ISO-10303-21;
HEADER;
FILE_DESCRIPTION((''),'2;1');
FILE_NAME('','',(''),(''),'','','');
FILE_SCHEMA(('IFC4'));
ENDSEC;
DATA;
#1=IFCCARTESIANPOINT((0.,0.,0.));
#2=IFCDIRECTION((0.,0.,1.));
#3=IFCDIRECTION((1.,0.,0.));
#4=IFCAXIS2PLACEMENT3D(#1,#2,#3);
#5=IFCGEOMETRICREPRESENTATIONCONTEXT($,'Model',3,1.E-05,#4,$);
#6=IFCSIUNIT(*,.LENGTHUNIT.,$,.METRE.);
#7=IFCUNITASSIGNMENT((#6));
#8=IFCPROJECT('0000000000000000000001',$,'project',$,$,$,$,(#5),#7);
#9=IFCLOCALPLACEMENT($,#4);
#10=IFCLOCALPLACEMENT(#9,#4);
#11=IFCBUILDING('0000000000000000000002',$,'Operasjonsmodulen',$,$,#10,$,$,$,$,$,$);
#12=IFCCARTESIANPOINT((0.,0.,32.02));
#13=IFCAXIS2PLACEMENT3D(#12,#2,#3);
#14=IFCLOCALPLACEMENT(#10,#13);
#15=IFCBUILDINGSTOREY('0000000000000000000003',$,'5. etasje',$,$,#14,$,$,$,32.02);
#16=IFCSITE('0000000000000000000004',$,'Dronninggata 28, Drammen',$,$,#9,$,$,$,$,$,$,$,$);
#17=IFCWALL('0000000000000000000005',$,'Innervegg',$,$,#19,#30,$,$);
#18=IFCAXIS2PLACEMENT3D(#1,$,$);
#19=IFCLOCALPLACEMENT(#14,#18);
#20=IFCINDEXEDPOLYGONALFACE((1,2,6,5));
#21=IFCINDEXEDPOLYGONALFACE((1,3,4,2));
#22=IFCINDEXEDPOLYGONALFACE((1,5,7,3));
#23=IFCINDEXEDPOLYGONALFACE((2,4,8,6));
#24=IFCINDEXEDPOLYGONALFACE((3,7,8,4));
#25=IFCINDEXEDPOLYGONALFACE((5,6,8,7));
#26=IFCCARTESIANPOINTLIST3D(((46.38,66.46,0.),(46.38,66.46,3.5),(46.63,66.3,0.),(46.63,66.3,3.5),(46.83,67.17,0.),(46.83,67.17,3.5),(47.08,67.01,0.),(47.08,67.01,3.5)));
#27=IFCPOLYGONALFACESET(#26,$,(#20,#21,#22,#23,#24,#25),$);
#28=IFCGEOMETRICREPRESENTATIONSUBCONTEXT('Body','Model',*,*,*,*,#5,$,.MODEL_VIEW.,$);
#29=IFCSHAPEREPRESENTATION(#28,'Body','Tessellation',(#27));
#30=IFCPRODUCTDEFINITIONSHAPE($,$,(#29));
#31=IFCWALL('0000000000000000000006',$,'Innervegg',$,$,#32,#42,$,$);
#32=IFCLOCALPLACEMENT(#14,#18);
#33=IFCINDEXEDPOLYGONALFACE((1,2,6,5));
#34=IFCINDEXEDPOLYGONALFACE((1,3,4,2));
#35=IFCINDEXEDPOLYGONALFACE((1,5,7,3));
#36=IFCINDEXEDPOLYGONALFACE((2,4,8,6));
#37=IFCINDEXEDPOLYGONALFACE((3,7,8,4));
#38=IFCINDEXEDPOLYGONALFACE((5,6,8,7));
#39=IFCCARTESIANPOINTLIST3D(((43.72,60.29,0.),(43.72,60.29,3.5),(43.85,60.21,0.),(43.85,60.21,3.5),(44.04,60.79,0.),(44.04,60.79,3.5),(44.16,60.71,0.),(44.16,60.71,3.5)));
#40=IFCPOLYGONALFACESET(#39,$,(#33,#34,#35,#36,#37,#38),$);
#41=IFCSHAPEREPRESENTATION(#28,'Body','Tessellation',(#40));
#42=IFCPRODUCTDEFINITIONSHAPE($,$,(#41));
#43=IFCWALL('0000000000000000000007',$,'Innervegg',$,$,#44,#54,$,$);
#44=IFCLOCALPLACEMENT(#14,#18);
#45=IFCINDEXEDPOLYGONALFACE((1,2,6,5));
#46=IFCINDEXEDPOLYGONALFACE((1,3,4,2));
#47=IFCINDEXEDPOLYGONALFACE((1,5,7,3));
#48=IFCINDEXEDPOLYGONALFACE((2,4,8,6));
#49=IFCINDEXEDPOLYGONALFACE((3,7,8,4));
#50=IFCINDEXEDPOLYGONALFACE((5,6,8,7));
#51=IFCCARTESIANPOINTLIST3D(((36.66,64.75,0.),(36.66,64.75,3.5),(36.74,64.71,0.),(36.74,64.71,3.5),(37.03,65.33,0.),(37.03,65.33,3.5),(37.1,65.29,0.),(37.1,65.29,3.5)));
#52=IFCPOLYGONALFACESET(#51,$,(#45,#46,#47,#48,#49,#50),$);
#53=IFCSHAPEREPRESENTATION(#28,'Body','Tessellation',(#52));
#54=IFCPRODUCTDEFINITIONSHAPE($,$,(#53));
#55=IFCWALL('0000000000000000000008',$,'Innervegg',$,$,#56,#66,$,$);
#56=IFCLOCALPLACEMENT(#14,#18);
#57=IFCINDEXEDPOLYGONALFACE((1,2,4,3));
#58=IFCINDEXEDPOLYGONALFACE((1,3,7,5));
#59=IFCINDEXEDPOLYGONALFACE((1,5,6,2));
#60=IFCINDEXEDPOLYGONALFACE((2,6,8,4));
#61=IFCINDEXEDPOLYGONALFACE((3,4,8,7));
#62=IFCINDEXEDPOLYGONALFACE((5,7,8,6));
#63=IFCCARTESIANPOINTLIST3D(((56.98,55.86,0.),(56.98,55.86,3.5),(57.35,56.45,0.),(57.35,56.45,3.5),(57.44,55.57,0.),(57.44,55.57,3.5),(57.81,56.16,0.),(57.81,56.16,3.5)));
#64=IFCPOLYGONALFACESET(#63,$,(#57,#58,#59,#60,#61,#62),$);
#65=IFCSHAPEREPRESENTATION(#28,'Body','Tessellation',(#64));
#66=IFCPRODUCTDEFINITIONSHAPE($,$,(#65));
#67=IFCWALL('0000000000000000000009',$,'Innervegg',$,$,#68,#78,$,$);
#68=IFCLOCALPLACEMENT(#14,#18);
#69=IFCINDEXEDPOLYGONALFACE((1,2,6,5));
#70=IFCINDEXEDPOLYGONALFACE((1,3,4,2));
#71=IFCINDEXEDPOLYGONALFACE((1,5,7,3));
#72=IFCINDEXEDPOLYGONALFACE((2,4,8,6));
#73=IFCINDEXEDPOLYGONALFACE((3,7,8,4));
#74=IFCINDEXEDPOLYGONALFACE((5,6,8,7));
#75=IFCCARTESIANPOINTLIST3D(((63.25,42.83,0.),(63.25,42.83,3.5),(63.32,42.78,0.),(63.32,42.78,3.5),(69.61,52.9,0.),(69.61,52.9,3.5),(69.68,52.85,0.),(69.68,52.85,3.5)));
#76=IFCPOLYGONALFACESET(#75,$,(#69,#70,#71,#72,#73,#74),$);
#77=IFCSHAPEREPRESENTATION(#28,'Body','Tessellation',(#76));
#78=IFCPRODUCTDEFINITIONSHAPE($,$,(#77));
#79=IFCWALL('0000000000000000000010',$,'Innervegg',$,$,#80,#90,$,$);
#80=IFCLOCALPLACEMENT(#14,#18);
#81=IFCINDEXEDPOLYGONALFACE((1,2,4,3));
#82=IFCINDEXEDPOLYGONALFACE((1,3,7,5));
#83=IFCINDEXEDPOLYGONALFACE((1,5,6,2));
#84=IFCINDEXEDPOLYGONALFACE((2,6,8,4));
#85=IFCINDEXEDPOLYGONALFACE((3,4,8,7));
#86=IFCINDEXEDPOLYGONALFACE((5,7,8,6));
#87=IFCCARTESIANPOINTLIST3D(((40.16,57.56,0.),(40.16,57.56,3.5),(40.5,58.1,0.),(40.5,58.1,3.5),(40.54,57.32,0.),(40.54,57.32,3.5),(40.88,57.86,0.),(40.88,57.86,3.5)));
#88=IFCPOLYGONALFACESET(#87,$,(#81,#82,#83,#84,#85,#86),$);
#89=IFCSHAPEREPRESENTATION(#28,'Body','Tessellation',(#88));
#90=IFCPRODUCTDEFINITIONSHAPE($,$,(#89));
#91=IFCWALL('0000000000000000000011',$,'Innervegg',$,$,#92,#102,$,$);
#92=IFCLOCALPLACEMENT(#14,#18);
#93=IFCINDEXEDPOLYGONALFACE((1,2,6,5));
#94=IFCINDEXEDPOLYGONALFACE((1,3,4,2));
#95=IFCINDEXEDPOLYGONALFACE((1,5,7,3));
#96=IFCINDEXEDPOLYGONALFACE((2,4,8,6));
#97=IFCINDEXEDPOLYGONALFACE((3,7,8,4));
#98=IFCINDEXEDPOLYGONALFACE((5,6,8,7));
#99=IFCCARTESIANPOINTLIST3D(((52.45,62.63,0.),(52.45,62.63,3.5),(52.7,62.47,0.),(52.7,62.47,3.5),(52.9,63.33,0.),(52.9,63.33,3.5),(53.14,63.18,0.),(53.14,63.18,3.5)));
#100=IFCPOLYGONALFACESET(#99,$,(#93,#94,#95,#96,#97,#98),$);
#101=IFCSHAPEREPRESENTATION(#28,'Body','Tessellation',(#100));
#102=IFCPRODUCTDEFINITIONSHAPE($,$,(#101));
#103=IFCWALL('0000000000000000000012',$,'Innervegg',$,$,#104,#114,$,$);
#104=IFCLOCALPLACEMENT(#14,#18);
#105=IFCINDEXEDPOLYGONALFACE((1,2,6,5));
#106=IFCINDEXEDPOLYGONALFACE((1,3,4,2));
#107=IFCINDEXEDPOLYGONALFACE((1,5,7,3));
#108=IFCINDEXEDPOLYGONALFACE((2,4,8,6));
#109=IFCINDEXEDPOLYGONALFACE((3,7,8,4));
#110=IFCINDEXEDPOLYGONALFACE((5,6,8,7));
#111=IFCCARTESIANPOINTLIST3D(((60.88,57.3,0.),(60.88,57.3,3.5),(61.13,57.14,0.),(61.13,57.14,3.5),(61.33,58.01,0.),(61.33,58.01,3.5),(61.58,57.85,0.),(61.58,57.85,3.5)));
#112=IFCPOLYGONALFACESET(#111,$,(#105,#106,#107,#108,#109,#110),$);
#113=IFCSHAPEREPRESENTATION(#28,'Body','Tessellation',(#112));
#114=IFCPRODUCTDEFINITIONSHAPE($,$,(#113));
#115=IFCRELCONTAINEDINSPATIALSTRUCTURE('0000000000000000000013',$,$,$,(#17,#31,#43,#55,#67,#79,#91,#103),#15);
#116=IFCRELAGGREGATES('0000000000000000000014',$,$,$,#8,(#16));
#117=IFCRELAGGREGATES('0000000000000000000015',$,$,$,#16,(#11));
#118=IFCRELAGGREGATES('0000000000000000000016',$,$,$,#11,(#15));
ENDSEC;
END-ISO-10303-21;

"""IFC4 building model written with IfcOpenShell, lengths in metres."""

from ifc_helpers import new_model, si_unit, frame, origin_with_axes, place, context, subcontext, project, spatial, polyline, outline, extrude, element, save


model = new_model("IFC4")

# Units and contexts
model_context = context("Model", 3, precision=1e-05, world=origin_with_axes())
body_context = subcontext(model_context, "Body", "Model", "MODEL_VIEW")
ifc_project = project(units=[si_unit("LENGTHUNIT", "METRE")], contexts=[model_context])

# Site, building, storey
site_placement = place(None, origin_with_axes())
site = spatial("IfcSite", under=ifc_project, at=site_placement, Name="Dronninggata 28, Drammen")
building_placement = place(site_placement, origin_with_axes())
building = spatial("IfcBuilding", under=site, at=building_placement, Name="Operasjonsmodulen")
storey_placement = place(building_placement, frame((0.0, 0.0, 32.02), z_axis=(0.0, 0.0, 1.0), x_axis=(1.0, 0.0, 0.0)))
storey = spatial("IfcBuildingStorey", under=building, at=storey_placement, Name="5. etasje", Elevation=32.02)

# Walls
wall_1_placement = place(storey_placement, frame((0.0, 0.0, -32.02), z_axis=(0.0, 0.0, 1.0), x_axis=(1.0, 0.0, 0.0)))
element("IfcWall", 1, at=wall_1_placement, inside=storey, Name="Innervegg", context=body_context, shape_type="SweptSolid", body=[
    extrude(outline(polyline([(47.08, 67.01), (46.63, 66.3), (46.38, 66.46), (46.83, 67.17), (47.08, 67.01)])), frame((0.0, 0.0, 32.02)), (0.0, 0.0, 1.0), 3.5),
])
wall_2_placement = place(storey_placement, frame((0.0, 0.0, -32.02), z_axis=(0.0, 0.0, 1.0), x_axis=(1.0, 0.0, 0.0)))
element("IfcWall", 2, at=wall_2_placement, inside=storey, Name="Innervegg", context=body_context, shape_type="SweptSolid", body=[
    extrude(outline(polyline([(44.16, 60.71), (43.85, 60.21), (43.72, 60.29), (44.04, 60.79), (44.16, 60.71)])), frame((0.0, 0.0, 32.02)), (0.0, 0.0, 1.0), 3.5),
])
wall_3_placement = place(storey_placement, frame((0.0, 0.0, -32.02), z_axis=(0.0, 0.0, 1.0), x_axis=(1.0, 0.0, 0.0)))
element("IfcWall", 3, at=wall_3_placement, inside=storey, Name="Innervegg", context=body_context, shape_type="SweptSolid", body=[
    extrude(outline(polyline([(37.1, 65.29), (36.74, 64.71), (36.66, 64.75), (37.03, 65.33), (37.1, 65.29)])), frame((0.0, 0.0, 32.02)), (0.0, 0.0, 1.0), 3.5),
])
wall_4_placement = place(storey_placement, frame((0.0, 0.0, -32.02), z_axis=(0.0, 0.0, 1.0), x_axis=(1.0, 0.0, 0.0)))
element("IfcWall", 4, at=wall_4_placement, inside=storey, Name="Innervegg", context=body_context, shape_type="SweptSolid", body=[
    extrude(outline(polyline([(57.81, 56.16), (57.44, 55.57), (56.98, 55.86), (57.35, 56.45), (57.81, 56.16)])), frame((0.0, 0.0, 32.02)), (0.0, 0.0, 1.0), 3.5),
])
wall_5_placement = place(storey_placement, frame((0.0, 0.0, -32.02), z_axis=(0.0, 0.0, 1.0), x_axis=(1.0, 0.0, 0.0)))
element("IfcWall", 5, at=wall_5_placement, inside=storey, Name="Innervegg", context=body_context, shape_type="SweptSolid", body=[
    extrude(outline(polyline([(69.68, 52.85), (63.32, 42.78), (63.25, 42.83), (69.61, 52.9), (69.68, 52.85)])), frame((0.0, 0.0, 32.02)), (0.0, 0.0, 1.0), 3.5),
])
wall_6_placement = place(storey_placement, frame((0.0, 0.0, -32.02), z_axis=(0.0, 0.0, 1.0), x_axis=(1.0, 0.0, 0.0)))
element("IfcWall", 6, at=wall_6_placement, inside=storey, Name="Innervegg", context=body_context, shape_type="SweptSolid", body=[
    extrude(outline(polyline([(40.88, 57.86), (40.54, 57.32), (40.16, 57.56), (40.5, 58.1), (40.88, 57.86)])), frame((0.0, 0.0, 32.02)), (0.0, 0.0, 1.0), 3.5),
])
wall_7_placement = place(storey_placement, frame((0.0, 0.0, -32.02), z_axis=(0.0, 0.0, 1.0), x_axis=(1.0, 0.0, 0.0)))
element("IfcWall", 7, at=wall_7_placement, inside=storey, Name="Innervegg", context=body_context, shape_type="SweptSolid", body=[
    extrude(outline(polyline([(53.14, 63.18), (52.7, 62.47), (52.45, 62.63), (52.9, 63.33), (53.14, 63.18)])), frame((0.0, 0.0, 32.02)), (0.0, 0.0, 1.0), 3.5),
])
wall_8_placement = place(storey_placement, frame((0.0, 0.0, -32.02), z_axis=(0.0, 0.0, 1.0), x_axis=(1.0, 0.0, 0.0)))
element("IfcWall", 8, at=wall_8_placement, inside=storey, Name="Innervegg", context=body_context, shape_type="SweptSolid", body=[
    extrude(outline(polyline([(61.58, 57.85), (61.13, 57.14), (60.88, 57.3), (61.33, 58.01), (61.58, 57.85)])), frame((0.0, 0.0, 32.02)), (0.0, 0.0, 1.0), 3.5),
])

save(model, "model.ifc")
